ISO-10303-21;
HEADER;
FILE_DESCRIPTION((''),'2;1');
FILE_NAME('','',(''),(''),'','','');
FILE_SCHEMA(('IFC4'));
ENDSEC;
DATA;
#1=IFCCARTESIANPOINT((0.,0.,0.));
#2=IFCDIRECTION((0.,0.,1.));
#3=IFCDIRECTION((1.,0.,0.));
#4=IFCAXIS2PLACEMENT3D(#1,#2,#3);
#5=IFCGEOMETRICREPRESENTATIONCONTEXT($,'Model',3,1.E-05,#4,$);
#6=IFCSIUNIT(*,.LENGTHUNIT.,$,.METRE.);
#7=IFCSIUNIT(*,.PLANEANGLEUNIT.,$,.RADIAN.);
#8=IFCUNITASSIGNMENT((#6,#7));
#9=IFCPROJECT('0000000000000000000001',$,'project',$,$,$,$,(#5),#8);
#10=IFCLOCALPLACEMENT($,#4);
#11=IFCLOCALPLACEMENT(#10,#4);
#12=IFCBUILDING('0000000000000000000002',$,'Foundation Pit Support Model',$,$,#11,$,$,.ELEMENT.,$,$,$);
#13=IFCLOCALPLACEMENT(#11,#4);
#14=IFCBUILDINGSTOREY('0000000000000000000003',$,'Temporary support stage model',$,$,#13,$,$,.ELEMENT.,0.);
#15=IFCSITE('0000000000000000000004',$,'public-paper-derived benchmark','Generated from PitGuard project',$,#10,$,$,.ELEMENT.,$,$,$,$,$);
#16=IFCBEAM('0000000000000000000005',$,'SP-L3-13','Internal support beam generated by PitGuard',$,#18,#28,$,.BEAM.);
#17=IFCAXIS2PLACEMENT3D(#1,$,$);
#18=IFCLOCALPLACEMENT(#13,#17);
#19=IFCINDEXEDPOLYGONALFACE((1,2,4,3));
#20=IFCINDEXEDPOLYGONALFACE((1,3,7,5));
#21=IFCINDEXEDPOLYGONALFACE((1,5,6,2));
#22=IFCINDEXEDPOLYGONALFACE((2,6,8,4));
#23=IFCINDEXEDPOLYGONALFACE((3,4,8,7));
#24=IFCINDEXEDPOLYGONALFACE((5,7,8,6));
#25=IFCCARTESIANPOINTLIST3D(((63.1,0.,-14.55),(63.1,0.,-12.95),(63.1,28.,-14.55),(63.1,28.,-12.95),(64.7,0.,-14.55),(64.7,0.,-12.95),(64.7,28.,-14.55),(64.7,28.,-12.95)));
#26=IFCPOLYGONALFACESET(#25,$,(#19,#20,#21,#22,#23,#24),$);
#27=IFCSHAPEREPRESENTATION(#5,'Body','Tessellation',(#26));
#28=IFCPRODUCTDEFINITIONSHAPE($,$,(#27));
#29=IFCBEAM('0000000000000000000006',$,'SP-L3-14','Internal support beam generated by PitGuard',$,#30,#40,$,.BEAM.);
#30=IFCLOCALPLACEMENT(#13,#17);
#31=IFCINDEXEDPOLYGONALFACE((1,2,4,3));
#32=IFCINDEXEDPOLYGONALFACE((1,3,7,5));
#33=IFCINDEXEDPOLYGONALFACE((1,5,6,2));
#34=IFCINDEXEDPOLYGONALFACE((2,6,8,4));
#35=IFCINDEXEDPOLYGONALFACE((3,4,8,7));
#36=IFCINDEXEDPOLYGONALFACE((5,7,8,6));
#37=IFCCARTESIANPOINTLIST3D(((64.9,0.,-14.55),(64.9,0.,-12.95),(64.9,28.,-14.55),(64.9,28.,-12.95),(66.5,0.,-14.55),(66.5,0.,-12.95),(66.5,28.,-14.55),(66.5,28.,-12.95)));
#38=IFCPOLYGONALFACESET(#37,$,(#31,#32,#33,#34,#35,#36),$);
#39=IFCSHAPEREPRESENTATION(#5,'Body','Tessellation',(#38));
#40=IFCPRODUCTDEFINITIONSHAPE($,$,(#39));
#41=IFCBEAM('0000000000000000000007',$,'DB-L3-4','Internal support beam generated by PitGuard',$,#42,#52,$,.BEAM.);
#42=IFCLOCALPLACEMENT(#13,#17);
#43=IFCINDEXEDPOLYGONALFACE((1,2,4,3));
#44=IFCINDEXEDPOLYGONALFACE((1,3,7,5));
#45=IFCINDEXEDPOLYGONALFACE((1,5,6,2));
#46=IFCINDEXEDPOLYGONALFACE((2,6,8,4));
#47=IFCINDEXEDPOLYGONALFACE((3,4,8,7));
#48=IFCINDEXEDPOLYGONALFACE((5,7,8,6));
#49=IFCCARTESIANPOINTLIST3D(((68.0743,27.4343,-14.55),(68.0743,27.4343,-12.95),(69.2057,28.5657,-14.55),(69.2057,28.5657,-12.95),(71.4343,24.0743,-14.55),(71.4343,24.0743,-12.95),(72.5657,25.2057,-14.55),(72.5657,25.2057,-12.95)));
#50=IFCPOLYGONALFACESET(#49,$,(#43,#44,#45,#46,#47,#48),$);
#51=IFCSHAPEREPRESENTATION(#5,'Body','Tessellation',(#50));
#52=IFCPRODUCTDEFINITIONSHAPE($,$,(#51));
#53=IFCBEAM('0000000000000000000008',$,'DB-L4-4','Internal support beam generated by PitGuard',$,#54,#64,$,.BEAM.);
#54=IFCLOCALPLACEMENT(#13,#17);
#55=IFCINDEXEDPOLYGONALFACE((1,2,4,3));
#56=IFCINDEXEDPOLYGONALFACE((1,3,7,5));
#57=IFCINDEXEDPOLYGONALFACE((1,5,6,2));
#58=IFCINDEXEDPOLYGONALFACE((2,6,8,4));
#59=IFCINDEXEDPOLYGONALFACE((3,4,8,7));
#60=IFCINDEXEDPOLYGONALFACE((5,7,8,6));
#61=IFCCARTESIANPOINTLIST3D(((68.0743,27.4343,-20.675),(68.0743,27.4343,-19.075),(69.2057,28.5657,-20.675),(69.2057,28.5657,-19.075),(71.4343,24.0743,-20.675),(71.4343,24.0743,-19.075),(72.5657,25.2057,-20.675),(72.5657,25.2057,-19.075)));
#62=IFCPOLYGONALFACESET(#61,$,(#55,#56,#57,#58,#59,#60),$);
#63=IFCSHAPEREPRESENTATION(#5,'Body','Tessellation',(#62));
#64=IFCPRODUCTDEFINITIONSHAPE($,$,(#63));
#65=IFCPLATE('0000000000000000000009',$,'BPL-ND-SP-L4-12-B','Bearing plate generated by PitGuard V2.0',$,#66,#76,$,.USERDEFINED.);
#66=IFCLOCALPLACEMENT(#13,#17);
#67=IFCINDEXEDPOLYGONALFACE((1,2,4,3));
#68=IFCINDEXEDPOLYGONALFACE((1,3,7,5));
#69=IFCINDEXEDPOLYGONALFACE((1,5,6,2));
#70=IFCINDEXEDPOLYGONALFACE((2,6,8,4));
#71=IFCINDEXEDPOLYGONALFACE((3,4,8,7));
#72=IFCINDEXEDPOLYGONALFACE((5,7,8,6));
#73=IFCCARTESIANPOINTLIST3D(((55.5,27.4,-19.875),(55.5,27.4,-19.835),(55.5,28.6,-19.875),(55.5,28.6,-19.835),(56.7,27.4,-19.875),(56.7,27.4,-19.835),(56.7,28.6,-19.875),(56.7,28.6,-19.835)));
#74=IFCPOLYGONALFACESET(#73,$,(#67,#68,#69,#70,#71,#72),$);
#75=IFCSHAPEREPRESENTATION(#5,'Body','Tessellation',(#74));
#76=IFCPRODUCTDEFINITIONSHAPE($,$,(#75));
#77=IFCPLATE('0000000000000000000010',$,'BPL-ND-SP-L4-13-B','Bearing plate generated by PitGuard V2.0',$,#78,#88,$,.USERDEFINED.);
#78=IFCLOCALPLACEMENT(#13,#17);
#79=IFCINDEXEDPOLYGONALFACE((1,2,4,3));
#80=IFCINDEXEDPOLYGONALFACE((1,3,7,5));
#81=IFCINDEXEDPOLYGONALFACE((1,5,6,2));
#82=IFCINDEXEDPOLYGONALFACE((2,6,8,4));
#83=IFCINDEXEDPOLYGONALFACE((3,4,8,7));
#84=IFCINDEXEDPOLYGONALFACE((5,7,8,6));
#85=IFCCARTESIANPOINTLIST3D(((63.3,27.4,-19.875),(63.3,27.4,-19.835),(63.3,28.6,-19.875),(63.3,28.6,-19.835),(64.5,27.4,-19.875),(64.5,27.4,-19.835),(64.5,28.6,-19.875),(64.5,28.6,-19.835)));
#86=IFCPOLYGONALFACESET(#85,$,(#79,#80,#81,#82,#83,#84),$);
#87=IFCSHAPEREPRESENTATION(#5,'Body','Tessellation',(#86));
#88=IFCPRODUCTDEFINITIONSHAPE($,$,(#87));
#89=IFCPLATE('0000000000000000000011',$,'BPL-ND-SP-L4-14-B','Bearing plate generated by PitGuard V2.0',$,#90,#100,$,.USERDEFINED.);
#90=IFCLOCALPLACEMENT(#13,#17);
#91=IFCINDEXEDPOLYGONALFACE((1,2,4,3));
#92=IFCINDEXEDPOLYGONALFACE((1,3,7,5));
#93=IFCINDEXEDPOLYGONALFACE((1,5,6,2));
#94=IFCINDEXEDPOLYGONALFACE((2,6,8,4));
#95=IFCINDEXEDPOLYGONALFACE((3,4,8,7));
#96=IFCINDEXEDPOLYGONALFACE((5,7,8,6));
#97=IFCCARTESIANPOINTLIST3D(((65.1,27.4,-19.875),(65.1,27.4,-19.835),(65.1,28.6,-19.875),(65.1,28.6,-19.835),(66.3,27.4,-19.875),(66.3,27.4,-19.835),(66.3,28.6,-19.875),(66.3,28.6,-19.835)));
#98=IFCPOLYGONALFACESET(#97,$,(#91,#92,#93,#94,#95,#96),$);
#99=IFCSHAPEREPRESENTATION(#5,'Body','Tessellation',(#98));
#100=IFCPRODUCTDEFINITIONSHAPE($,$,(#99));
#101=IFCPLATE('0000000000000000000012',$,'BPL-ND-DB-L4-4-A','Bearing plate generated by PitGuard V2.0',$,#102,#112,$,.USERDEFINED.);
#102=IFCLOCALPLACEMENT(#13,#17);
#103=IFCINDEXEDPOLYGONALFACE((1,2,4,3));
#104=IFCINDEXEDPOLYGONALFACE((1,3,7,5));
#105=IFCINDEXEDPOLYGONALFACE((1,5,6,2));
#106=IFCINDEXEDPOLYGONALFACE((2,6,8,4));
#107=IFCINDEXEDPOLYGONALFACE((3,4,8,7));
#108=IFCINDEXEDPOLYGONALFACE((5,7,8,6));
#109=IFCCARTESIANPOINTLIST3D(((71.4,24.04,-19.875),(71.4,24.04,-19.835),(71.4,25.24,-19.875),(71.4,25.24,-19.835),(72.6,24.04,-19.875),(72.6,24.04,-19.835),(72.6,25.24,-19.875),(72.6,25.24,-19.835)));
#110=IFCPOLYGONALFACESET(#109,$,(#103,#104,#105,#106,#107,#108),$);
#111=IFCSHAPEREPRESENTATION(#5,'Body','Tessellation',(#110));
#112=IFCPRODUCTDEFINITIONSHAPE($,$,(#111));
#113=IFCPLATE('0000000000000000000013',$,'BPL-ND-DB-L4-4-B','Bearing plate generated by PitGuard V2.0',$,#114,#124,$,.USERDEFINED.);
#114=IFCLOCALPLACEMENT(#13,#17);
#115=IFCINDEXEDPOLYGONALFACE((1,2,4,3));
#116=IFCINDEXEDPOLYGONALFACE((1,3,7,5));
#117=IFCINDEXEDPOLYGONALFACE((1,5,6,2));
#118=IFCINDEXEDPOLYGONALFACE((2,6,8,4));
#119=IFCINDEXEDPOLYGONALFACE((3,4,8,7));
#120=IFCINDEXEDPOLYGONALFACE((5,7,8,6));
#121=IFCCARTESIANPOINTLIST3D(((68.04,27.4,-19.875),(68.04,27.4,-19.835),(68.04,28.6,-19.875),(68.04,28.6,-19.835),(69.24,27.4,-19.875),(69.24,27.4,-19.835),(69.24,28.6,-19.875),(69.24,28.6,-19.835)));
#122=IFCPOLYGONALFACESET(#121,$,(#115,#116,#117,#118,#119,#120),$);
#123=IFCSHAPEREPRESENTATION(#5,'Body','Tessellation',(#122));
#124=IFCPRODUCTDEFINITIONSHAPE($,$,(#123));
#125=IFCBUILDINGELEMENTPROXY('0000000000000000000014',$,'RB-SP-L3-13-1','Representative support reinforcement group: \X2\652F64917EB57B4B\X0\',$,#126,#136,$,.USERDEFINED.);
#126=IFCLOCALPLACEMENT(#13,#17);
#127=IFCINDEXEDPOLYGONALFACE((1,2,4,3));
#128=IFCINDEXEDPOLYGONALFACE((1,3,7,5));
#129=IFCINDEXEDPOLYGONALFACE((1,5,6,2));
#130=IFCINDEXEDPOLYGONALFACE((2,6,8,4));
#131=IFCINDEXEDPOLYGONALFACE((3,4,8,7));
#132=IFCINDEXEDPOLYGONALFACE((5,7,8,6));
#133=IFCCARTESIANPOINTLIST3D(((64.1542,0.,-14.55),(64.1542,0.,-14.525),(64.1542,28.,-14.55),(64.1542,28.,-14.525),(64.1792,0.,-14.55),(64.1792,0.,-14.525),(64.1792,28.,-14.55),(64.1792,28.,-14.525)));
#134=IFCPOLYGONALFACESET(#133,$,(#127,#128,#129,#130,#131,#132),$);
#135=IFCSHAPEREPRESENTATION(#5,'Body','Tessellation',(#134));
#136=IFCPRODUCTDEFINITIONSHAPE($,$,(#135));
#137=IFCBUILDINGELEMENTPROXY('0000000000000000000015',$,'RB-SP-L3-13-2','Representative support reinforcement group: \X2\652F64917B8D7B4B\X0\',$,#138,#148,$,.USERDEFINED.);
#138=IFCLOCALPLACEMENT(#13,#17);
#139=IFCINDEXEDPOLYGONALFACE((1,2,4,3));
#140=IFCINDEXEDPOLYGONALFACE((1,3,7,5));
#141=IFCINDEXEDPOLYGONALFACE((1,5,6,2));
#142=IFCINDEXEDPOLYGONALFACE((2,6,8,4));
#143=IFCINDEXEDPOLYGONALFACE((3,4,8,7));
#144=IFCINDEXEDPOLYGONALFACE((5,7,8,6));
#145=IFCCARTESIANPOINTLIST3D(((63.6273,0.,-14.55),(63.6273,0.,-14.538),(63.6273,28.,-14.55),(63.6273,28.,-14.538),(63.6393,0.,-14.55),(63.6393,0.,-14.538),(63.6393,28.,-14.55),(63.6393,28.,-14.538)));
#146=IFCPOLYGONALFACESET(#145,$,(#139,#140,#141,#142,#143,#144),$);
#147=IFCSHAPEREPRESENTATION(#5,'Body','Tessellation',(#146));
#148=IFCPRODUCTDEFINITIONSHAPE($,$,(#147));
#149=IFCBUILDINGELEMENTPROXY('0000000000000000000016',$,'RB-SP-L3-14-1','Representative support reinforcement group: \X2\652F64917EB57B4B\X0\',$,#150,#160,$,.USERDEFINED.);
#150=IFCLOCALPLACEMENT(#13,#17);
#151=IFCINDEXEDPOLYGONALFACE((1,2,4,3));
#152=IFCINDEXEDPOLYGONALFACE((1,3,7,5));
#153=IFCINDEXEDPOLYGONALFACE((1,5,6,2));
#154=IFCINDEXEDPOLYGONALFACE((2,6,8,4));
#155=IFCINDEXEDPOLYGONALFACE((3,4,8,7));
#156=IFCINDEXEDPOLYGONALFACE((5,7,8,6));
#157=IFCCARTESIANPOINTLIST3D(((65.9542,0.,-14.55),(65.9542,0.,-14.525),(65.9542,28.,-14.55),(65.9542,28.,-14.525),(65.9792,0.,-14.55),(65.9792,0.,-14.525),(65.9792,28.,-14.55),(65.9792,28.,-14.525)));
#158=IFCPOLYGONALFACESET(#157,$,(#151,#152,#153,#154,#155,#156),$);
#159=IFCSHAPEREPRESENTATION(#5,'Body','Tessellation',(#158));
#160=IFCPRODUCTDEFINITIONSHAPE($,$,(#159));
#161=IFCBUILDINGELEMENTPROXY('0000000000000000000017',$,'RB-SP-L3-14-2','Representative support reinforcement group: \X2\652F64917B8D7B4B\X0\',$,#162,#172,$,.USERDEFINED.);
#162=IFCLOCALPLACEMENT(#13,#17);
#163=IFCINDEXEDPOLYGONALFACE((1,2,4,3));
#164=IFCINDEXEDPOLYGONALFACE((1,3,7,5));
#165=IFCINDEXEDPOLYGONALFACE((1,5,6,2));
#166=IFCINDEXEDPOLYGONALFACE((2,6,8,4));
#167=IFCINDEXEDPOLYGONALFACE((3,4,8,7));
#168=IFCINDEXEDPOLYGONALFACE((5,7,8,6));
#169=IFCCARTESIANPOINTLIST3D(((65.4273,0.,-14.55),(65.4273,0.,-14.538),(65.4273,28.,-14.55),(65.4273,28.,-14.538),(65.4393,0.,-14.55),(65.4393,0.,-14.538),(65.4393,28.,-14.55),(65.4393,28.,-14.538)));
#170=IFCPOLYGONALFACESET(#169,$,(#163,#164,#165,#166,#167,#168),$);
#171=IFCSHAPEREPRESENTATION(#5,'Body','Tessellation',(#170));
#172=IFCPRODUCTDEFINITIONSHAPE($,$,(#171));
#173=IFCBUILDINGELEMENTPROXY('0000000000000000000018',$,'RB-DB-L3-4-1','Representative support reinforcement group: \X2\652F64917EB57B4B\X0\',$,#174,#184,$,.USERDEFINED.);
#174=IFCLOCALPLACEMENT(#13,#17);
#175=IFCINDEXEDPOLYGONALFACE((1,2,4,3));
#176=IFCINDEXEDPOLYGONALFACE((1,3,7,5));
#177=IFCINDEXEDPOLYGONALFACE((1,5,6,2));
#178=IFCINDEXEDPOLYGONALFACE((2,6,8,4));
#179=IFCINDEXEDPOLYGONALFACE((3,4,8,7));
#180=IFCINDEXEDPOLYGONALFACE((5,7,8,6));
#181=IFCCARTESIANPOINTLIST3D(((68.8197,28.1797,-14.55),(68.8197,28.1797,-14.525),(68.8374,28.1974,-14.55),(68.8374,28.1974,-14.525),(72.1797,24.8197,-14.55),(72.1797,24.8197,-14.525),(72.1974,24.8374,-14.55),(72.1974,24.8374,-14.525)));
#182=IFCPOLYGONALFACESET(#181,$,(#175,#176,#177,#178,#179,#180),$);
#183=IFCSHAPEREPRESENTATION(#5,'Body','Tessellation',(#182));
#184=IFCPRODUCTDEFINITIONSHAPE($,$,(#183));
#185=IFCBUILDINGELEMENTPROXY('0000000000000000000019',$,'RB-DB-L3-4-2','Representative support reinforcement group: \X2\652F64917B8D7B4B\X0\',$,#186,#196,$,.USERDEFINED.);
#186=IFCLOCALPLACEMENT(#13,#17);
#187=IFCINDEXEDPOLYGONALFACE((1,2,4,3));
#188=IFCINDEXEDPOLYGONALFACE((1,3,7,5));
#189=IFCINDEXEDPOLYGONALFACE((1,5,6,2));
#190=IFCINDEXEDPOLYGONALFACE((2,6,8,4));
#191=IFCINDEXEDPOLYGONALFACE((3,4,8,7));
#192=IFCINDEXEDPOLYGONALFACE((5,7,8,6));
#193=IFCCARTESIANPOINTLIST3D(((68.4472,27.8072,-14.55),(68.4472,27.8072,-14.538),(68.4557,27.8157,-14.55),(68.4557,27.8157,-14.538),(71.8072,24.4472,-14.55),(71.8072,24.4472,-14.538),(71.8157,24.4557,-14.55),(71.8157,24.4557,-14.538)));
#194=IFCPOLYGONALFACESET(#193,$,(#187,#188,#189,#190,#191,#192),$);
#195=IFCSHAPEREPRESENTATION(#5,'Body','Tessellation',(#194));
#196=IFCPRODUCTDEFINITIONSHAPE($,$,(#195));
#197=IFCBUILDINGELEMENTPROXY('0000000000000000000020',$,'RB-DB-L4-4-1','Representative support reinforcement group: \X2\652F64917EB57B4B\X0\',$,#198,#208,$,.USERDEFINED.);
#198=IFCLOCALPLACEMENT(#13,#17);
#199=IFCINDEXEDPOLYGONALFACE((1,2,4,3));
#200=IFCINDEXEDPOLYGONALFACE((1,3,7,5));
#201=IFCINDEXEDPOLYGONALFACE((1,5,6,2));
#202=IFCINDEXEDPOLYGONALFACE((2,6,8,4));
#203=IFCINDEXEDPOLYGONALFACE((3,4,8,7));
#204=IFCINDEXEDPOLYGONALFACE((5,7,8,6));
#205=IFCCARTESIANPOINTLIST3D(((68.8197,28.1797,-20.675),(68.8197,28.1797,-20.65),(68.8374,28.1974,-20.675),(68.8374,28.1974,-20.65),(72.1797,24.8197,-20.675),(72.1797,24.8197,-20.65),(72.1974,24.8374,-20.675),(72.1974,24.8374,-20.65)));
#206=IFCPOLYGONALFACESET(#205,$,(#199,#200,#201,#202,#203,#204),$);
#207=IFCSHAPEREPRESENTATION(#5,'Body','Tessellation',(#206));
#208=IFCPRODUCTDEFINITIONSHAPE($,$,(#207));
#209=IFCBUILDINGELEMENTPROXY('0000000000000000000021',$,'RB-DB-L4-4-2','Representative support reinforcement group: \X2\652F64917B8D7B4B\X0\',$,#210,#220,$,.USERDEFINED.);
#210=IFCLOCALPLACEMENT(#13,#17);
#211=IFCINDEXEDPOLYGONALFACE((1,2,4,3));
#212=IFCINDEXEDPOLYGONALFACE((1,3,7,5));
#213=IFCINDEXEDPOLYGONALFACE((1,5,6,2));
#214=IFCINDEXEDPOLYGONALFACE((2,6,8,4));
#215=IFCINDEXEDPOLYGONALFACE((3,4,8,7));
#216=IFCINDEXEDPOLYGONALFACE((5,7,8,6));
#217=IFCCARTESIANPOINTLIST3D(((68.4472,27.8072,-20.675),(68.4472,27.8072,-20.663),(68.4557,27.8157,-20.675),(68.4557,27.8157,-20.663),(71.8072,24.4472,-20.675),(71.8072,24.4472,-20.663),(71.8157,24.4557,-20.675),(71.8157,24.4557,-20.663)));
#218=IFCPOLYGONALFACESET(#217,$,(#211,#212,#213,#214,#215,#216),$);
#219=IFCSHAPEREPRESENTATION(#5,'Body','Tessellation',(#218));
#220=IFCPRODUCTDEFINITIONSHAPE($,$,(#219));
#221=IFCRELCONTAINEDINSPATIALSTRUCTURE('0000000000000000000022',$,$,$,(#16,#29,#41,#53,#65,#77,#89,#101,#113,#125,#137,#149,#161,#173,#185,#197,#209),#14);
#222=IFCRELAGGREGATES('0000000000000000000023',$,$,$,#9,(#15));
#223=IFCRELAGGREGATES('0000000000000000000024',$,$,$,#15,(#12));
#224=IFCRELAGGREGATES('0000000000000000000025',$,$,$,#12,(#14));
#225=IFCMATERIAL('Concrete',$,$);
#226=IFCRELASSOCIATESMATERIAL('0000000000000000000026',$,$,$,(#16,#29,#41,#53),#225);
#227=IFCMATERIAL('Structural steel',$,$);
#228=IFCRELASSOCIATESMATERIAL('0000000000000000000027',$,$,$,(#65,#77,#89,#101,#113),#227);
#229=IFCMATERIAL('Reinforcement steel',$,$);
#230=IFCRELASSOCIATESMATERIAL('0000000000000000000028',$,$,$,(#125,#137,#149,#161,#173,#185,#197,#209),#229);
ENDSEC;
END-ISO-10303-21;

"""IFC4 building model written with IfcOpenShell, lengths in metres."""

from ifc_helpers import new_model, si_unit, frame, origin_with_axes, origin_2d, place, context, project, spatial, rectangle, extrude, material, element, save


model = new_model("IFC4")

# Units and contexts
model_context = context("Model", 3, precision=1e-05, world=origin_with_axes())
ifc_project = project(units=[si_unit("LENGTHUNIT", "METRE"), si_unit("PLANEANGLEUNIT", "RADIAN")], contexts=[model_context])

# Site, building, storey
site_placement = place(None, origin_with_axes())
site = spatial("IfcSite", under=ifc_project, at=site_placement, Name="public-paper-derived benchmark", Description="Generated from PitGuard project", CompositionType="ELEMENT")
building_placement = place(site_placement, origin_with_axes())
building = spatial("IfcBuilding", under=site, at=building_placement, Name="Foundation Pit Support Model", CompositionType="ELEMENT")
storey_placement = place(building_placement, origin_with_axes())
storey = spatial("IfcBuildingStorey", under=building, at=storey_placement, Name="Temporary support stage model", CompositionType="ELEMENT", Elevation=0.0)

# Beams
ifc_material_1 = material(Name="Concrete")
for number, where, z_axis, x_axis, name in (
    (1, (63.9, 14.0, -14.55), (0.0, 0.0, 1.0), (0.0, 1.0, 0.0), "SP-L3-13"),
    (2, (65.7, 14.0, -14.55), (0.0, 0.0, 1.0), (0.0, 1.0, 0.0), "SP-L3-14"),
):
    element("IfcBeam", number, at=place(storey_placement, frame(where, z_axis=z_axis, x_axis=x_axis)), inside=storey, material=ifc_material_1, Name=name, Description="Internal support beam generated by PitGuard", PredefinedType="BEAM", context=model_context, shape_type="SweptSolid", body=[
        extrude(rectangle(XDim=28.0, YDim=1.6, at=origin_2d()), origin_with_axes(), (0.0, 0.0, 1.0), 1.6),
    ])
for number, where, z_axis, x_axis, name in (
    (3, (70.32, 26.32, -14.55), (0.0, 0.0, 1.0), (-0.707107, 0.707107, 0.0), "DB-L3-4"),
    (4, (70.32, 26.32, -20.675), (0.0, 0.0, 1.0), (-0.707107, 0.707107, 0.0), "DB-L4-4"),
):
    element("IfcBeam", number, at=place(storey_placement, frame(where, z_axis=z_axis, x_axis=x_axis)), inside=storey, material=ifc_material_1, Name=name, Description="Internal support beam generated by PitGuard", PredefinedType="BEAM", context=model_context, shape_type="SweptSolid", body=[
        extrude(rectangle(XDim=4.7518, YDim=1.6, at=origin_2d()), origin_with_axes(), (0.0, 0.0, 1.0), 1.6),
    ])

# Plates
ifc_material_2 = material(Name="Structural steel")
for number, where, z_axis, x_axis, name in (
    (5, (56.1, 28.0, -19.875), (0.0, 0.0, 1.0), (1.0, 0.0, 0.0), "BPL-ND-SP-L4-12-B"),
    (6, (63.9, 28.0, -19.875), (0.0, 0.0, 1.0), (1.0, 0.0, 0.0), "BPL-ND-SP-L4-13-B"),
    (7, (65.7, 28.0, -19.875), (0.0, 0.0, 1.0), (1.0, 0.0, 0.0), "BPL-ND-SP-L4-14-B"),
    (8, (72.0, 24.64, -19.875), (0.0, 0.0, 1.0), (1.0, 0.0, 0.0), "BPL-ND-DB-L4-4-A"),
    (9, (68.64, 28.0, -19.875), (0.0, 0.0, 1.0), (1.0, 0.0, 0.0), "BPL-ND-DB-L4-4-B"),
):
    element("IfcPlate", number, at=place(storey_placement, frame(where, z_axis=z_axis, x_axis=x_axis)), inside=storey, material=ifc_material_2, Name=name, Description="Bearing plate generated by PitGuard V2.0", PredefinedType="USERDEFINED", context=model_context, shape_type="SweptSolid", body=[
        extrude(rectangle(XDim=1.2, YDim=1.2, at=origin_2d()), origin_with_axes(), (0.0, 0.0, 1.0), 0.04),
    ])

# Building element proxies
ifc_material_3 = material(Name="Reinforcement steel")
proxy_1_placement = place(storey_placement, frame((64.1667, 14.0, -14.55), z_axis=(0.0, 0.0, 1.0), x_axis=(0.0, 1.0, 0.0)))
element("IfcBuildingElementProxy", 10, at=proxy_1_placement, inside=storey, material=ifc_material_3, Name="RB-SP-L3-13-1", Description="Representative support reinforcement group: 支撑纵筋", PredefinedType="USERDEFINED", context=model_context, shape_type="SweptSolid", body=[
    extrude(rectangle(XDim=28.0, YDim=0.025, at=origin_2d()), origin_with_axes(), (0.0, 0.0, 1.0), 0.025),
])
proxy_2_placement = place(storey_placement, frame((63.6333, 14.0, -14.55), z_axis=(0.0, 0.0, 1.0), x_axis=(0.0, 1.0, 0.0)))
element("IfcBuildingElementProxy", 11, at=proxy_2_placement, inside=storey, material=ifc_material_3, Name="RB-SP-L3-13-2", Description="Representative support reinforcement group: 支撑箍筋", PredefinedType="USERDEFINED", context=model_context, shape_type="SweptSolid", body=[
    extrude(rectangle(XDim=28.0, YDim=0.012, at=origin_2d()), origin_with_axes(), (0.0, 0.0, 1.0), 0.012),
])
proxy_3_placement = place(storey_placement, frame((65.9667, 14.0, -14.55), z_axis=(0.0, 0.0, 1.0), x_axis=(0.0, 1.0, 0.0)))
element("IfcBuildingElementProxy", 12, at=proxy_3_placement, inside=storey, material=ifc_material_3, Name="RB-SP-L3-14-1", Description="Representative support reinforcement group: 支撑纵筋", PredefinedType="USERDEFINED", context=model_context, shape_type="SweptSolid", body=[
    extrude(rectangle(XDim=28.0, YDim=0.025, at=origin_2d()), origin_with_axes(), (0.0, 0.0, 1.0), 0.025),
])
proxy_4_placement = place(storey_placement, frame((65.4333, 14.0, -14.55), z_axis=(0.0, 0.0, 1.0), x_axis=(0.0, 1.0, 0.0)))
element("IfcBuildingElementProxy", 13, at=proxy_4_placement, inside=storey, material=ifc_material_3, Name="RB-SP-L3-14-2", Description="Representative support reinforcement group: 支撑箍筋", PredefinedType="USERDEFINED", context=model_context, shape_type="SweptSolid", body=[
    extrude(rectangle(XDim=28.0, YDim=0.012, at=origin_2d()), origin_with_axes(), (0.0, 0.0, 1.0), 0.012),
])
proxy_5_placement = place(storey_placement, frame((70.5086, 26.5086, -14.55), z_axis=(0.0, 0.0, 1.0), x_axis=(-0.707107, 0.707107, 0.0)))
element("IfcBuildingElementProxy", 14, at=proxy_5_placement, inside=storey, material=ifc_material_3, Name="RB-DB-L3-4-1", Description="Representative support reinforcement group: 支撑纵筋", PredefinedType="USERDEFINED", context=model_context, shape_type="SweptSolid", body=[
    extrude(rectangle(XDim=4.7518, YDim=0.025, at=origin_2d()), origin_with_axes(), (0.0, 0.0, 1.0), 0.025),
])
proxy_6_placement = place(storey_placement, frame((70.1314, 26.1314, -14.55), z_axis=(0.0, 0.0, 1.0), x_axis=(-0.707107, 0.707107, 0.0)))
element("IfcBuildingElementProxy", 15, at=proxy_6_placement, inside=storey, material=ifc_material_3, Name="RB-DB-L3-4-2", Description="Representative support reinforcement group: 支撑箍筋", PredefinedType="USERDEFINED", context=model_context, shape_type="SweptSolid", body=[
    extrude(rectangle(XDim=4.7518, YDim=0.012, at=origin_2d()), origin_with_axes(), (0.0, 0.0, 1.0), 0.012),
])
proxy_7_placement = place(storey_placement, frame((70.5086, 26.5086, -20.675), z_axis=(0.0, 0.0, 1.0), x_axis=(-0.707107, 0.707107, 0.0)))
element("IfcBuildingElementProxy", 16, at=proxy_7_placement, inside=storey, material=ifc_material_3, Name="RB-DB-L4-4-1", Description="Representative support reinforcement group: 支撑纵筋", PredefinedType="USERDEFINED", context=model_context, shape_type="SweptSolid", body=[
    extrude(rectangle(XDim=4.7518, YDim=0.025, at=origin_2d()), origin_with_axes(), (0.0, 0.0, 1.0), 0.025),
])
proxy_8_placement = place(storey_placement, frame((70.1314, 26.1314, -20.675), z_axis=(0.0, 0.0, 1.0), x_axis=(-0.707107, 0.707107, 0.0)))
element("IfcBuildingElementProxy", 17, at=proxy_8_placement, inside=storey, material=ifc_material_3, Name="RB-DB-L4-4-2", Description="Representative support reinforcement group: 支撑箍筋", PredefinedType="USERDEFINED", context=model_context, shape_type="SweptSolid", body=[
    extrude(rectangle(XDim=4.7518, YDim=0.012, at=origin_2d()), origin_with_axes(), (0.0, 0.0, 1.0), 0.012),
])

save(model, "model.ifc")
